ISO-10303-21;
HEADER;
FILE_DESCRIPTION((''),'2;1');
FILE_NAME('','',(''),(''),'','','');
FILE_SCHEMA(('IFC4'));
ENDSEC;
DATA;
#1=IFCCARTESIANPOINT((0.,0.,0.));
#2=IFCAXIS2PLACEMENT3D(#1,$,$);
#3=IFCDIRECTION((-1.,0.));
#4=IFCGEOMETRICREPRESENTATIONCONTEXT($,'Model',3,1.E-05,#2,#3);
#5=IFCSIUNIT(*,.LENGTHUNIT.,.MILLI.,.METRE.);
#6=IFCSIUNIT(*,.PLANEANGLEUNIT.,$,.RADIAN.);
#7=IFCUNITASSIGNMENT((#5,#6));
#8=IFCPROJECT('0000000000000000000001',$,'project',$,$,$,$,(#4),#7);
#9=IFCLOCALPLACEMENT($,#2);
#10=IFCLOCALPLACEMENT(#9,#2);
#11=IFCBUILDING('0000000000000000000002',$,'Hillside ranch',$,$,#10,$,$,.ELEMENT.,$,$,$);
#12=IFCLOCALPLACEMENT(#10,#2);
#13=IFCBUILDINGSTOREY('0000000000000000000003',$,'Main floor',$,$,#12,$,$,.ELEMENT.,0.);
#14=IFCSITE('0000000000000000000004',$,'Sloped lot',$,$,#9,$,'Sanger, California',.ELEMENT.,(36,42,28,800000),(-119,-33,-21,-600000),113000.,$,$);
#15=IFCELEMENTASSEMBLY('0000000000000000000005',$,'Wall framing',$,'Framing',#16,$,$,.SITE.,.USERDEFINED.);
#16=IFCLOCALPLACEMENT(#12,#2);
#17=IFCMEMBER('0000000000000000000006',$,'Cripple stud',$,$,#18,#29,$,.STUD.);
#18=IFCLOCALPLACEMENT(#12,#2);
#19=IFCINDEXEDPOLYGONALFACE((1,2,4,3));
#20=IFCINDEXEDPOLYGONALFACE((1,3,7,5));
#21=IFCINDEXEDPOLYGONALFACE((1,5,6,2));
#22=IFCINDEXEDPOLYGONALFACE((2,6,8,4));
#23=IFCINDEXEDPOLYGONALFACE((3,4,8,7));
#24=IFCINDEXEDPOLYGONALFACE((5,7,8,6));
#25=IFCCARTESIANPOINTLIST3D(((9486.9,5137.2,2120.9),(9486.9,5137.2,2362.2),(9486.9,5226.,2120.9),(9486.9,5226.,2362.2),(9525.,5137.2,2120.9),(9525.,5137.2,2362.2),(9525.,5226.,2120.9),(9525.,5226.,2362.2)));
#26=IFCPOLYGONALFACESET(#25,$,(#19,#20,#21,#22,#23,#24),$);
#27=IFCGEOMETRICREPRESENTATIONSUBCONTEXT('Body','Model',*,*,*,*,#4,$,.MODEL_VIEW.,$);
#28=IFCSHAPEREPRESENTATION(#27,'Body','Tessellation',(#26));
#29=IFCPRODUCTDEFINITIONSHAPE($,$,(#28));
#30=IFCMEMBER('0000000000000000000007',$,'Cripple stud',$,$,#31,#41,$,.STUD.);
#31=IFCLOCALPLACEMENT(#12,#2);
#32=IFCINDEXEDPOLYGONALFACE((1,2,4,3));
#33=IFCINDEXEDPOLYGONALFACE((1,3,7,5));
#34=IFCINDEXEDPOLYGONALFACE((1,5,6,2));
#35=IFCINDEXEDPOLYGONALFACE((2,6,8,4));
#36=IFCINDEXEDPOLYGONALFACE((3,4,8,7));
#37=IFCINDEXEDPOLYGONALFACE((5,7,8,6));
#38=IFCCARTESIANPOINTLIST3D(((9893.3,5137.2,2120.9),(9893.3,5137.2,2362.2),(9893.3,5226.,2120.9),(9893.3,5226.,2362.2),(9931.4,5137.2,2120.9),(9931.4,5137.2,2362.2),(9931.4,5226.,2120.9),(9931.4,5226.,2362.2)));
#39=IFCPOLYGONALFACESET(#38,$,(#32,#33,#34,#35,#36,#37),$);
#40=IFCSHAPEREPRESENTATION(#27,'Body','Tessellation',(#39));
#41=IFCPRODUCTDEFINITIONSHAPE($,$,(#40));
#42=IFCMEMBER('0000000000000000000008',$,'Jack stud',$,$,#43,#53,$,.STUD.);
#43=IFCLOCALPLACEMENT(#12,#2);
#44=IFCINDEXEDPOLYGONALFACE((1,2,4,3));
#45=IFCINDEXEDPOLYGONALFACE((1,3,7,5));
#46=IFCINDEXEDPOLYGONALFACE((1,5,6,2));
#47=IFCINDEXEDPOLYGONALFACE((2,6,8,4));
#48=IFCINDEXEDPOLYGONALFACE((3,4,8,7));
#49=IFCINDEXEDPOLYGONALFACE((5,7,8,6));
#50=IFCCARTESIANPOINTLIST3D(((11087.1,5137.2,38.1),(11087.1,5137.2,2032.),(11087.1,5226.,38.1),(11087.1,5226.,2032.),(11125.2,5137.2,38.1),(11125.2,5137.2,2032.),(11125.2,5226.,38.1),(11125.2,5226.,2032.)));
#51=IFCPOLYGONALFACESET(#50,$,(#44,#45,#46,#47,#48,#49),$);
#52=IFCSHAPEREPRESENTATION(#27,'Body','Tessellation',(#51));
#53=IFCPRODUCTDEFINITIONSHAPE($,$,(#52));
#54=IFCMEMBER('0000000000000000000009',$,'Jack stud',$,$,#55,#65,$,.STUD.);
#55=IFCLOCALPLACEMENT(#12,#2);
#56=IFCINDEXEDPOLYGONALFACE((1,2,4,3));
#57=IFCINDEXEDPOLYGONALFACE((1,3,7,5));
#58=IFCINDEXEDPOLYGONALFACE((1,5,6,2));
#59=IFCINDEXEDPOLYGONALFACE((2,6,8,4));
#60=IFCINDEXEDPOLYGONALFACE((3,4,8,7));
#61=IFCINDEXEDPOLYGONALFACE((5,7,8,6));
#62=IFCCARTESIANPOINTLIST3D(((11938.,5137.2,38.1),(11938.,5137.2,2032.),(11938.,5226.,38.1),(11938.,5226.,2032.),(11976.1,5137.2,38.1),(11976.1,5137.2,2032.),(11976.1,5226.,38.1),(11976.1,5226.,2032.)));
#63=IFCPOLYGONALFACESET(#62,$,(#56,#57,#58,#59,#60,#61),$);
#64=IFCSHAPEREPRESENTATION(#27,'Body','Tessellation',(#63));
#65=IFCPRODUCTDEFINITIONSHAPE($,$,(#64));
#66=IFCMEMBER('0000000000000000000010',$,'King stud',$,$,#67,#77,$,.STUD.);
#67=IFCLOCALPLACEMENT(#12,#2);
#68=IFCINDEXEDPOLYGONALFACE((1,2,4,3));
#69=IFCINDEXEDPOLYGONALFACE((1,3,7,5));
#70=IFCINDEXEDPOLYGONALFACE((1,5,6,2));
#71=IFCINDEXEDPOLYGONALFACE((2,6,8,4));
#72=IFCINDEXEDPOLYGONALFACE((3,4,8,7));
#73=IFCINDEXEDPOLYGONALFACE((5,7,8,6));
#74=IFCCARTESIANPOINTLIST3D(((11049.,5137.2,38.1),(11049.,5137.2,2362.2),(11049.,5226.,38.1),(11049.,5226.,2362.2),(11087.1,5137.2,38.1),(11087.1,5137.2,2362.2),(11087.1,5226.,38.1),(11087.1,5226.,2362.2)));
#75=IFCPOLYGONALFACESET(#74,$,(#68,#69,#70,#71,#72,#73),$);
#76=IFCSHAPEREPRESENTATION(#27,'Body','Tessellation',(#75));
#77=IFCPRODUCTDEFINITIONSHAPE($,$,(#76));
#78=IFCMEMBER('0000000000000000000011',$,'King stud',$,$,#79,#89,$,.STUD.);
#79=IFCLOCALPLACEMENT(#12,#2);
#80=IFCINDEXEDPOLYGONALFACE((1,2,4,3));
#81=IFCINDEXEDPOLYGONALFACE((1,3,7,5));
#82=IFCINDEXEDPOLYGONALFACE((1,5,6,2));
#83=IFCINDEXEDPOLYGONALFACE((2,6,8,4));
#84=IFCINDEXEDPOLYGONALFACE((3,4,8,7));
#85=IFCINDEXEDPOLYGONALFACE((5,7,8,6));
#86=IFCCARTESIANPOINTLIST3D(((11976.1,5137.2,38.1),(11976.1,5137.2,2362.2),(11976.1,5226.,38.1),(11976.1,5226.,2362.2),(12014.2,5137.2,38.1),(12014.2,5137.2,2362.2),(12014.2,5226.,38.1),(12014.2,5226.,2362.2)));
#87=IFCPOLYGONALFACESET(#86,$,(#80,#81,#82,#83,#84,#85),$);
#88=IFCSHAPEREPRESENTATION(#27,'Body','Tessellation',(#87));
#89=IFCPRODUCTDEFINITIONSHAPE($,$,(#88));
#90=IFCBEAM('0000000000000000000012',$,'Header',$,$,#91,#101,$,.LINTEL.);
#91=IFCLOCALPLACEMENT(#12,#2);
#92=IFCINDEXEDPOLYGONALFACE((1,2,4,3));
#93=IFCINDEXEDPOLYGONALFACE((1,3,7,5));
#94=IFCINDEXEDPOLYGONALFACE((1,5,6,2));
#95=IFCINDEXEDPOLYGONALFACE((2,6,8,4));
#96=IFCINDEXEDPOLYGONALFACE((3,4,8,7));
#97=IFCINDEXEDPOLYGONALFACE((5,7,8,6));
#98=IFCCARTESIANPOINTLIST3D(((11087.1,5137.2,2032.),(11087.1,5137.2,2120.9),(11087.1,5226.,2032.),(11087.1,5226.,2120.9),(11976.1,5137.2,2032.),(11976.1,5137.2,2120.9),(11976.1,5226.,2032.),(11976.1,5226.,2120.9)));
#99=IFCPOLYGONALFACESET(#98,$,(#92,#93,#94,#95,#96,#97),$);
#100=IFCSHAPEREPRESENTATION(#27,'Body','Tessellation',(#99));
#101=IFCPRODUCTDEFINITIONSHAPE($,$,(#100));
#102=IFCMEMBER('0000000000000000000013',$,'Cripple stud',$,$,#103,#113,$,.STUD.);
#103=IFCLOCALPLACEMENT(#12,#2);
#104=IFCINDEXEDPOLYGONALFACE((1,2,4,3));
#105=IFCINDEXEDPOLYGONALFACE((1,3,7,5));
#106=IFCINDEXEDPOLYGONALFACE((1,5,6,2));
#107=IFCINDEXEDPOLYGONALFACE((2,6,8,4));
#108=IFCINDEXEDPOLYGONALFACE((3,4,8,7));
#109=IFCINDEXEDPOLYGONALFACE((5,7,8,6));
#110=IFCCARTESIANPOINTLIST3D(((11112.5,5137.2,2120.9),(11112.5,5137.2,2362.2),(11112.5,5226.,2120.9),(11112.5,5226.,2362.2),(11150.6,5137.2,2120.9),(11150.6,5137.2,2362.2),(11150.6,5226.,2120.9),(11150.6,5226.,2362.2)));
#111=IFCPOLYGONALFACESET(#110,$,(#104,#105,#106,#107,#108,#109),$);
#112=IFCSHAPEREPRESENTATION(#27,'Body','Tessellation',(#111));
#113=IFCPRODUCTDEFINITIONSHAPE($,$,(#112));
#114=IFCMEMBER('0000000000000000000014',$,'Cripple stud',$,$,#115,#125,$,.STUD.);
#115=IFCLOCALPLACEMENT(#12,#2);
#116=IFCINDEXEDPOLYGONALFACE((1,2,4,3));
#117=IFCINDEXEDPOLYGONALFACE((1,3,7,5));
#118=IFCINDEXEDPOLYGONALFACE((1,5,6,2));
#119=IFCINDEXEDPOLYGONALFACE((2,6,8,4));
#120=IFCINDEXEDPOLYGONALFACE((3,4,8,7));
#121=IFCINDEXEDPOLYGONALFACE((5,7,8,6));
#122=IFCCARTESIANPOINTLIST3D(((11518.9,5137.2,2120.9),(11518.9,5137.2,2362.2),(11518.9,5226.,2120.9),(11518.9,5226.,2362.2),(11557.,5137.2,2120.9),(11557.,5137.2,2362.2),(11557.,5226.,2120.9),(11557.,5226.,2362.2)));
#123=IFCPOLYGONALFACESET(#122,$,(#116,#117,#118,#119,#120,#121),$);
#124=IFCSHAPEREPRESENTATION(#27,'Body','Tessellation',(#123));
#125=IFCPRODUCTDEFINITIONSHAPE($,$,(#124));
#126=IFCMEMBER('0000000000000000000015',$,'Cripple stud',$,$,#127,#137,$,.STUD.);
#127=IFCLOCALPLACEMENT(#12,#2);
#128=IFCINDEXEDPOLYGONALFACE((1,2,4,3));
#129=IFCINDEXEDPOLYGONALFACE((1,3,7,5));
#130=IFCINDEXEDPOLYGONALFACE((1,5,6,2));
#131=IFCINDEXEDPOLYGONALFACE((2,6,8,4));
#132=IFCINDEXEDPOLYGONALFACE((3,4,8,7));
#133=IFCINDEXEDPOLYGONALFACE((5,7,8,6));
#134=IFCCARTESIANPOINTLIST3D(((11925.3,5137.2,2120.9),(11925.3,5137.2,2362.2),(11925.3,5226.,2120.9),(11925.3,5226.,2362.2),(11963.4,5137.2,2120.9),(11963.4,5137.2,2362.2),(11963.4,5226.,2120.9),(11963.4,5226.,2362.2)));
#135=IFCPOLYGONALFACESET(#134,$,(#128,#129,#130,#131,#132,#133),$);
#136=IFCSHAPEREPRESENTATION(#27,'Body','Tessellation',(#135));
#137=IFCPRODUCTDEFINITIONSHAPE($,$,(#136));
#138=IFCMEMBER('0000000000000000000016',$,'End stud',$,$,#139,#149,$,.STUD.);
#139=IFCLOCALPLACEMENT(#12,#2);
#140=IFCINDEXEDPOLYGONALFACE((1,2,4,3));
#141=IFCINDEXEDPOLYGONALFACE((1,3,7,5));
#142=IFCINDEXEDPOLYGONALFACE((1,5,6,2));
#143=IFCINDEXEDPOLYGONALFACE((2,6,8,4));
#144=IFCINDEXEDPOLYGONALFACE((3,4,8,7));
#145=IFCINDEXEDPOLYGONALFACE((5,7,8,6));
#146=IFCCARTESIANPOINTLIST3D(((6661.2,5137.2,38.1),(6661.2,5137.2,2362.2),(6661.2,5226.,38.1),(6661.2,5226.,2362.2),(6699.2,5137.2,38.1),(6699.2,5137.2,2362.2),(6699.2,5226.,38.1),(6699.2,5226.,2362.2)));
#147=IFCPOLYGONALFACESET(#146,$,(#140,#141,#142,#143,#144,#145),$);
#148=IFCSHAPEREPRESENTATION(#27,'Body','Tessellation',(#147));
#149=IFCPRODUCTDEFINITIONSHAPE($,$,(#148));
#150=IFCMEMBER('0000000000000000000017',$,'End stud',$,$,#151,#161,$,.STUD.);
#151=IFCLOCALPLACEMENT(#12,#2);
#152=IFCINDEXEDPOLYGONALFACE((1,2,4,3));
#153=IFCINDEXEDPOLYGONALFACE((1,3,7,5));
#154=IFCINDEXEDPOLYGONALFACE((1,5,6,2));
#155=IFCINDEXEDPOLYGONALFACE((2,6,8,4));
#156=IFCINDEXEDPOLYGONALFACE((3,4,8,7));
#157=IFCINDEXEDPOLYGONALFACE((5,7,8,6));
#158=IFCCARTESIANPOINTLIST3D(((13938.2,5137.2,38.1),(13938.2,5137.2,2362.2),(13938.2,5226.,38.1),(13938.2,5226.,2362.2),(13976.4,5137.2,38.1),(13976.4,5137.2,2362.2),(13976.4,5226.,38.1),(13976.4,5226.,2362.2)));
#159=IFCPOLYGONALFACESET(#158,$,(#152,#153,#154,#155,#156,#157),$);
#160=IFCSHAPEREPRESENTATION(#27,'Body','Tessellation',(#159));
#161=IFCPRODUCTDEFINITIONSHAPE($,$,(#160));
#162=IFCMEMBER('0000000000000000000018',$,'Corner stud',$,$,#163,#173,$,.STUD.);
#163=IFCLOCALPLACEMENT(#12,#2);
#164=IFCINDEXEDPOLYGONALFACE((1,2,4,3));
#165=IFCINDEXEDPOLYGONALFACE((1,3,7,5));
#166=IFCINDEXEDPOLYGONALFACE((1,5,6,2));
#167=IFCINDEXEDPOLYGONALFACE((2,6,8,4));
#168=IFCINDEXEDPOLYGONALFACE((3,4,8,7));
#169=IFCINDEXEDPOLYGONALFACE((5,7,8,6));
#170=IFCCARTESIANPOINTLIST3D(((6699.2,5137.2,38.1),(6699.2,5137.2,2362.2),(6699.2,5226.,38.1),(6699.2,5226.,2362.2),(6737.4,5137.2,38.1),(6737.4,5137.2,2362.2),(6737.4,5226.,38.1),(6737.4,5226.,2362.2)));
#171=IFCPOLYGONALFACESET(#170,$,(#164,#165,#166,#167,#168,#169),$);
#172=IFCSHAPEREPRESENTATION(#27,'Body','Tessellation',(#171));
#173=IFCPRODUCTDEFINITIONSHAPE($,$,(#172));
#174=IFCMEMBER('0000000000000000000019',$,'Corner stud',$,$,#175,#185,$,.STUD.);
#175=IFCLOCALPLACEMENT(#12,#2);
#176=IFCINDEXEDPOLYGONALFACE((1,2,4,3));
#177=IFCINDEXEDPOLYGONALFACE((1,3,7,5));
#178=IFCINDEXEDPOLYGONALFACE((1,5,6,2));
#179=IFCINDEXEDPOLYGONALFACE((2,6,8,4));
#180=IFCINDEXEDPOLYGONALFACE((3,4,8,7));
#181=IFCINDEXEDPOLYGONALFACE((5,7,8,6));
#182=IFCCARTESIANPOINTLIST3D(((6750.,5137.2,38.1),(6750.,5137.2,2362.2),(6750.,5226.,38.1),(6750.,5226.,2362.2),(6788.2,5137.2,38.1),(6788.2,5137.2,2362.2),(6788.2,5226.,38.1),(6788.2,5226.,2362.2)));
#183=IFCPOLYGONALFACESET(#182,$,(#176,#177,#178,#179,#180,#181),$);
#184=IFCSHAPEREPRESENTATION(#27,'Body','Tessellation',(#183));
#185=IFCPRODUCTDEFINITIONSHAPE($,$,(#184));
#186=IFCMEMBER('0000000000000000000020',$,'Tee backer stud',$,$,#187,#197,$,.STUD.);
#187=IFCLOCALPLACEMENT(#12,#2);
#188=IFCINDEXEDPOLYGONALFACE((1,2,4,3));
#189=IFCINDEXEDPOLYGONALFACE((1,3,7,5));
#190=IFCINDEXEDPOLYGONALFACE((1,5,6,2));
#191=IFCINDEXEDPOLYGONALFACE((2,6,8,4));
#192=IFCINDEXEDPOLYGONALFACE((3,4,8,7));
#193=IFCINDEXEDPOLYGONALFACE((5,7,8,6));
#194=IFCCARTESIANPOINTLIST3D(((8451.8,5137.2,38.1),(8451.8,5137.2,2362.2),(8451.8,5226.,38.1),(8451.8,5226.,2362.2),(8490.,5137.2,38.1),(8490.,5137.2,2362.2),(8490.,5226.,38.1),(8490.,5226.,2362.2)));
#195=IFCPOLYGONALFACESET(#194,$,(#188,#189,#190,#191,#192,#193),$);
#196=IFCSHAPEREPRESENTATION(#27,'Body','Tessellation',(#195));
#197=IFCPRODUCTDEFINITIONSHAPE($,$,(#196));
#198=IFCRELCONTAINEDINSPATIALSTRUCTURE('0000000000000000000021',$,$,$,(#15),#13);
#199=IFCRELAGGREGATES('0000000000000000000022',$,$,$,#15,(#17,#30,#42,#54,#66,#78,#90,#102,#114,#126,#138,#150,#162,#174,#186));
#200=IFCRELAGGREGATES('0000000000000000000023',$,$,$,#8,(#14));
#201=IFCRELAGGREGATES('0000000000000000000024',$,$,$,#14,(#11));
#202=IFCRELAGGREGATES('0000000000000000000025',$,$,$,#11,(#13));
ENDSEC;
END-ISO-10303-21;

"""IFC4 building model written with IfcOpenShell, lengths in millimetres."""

from ifc_helpers import new_model, si_unit, direction, frame, origin, origin_with_axes, place, context, subcontext, project, spatial, polyline, outline, extrude, element, aggregate, save


model = new_model("IFC4")

# Units and contexts
model_context = context("Model", 3, precision=1e-05, world=origin(), true_north=direction((-1.0, 0.0)))
body_context = subcontext(model_context, "Body", "Model", "MODEL_VIEW")
ifc_project = project(units=[si_unit("LENGTHUNIT", "METRE", prefix="MILLI"), si_unit("PLANEANGLEUNIT", "RADIAN")], contexts=[model_context])

# Site, building, storey
site_placement = place(None, origin())
site = spatial("IfcSite", under=ifc_project, at=site_placement, Name="Sloped lot", LongName="Sanger, California", CompositionType="ELEMENT", RefLatitude=(36, 42, 28, 800000), RefLongitude=(-119, -33, -21, -600000), RefElevation=113000.0)
building_placement = place(site_placement, origin())
building = spatial("IfcBuilding", under=site, at=building_placement, Name="Hillside ranch", CompositionType="ELEMENT")
storey_placement = place(building_placement, origin())
storey = spatial("IfcBuildingStorey", under=building, at=storey_placement, Name="Main floor", CompositionType="ELEMENT", Elevation=0.0)

# Element assembly, members, beam
assembly_placement = place(storey_placement, origin_with_axes())
assembly = element("IfcElementAssembly", 1, at=assembly_placement, inside=storey, Name="Wall framing", ObjectType="Framing", AssemblyPlace="SITE", PredefinedType="USERDEFINED")
member_1_placement = place(storey_placement, origin_with_axes())
member_1 = element("IfcMember", 2, at=member_1_placement, Name="Cripple stud", PredefinedType="STUD", context=body_context, shape_type="SweptSolid", body=[
    extrude(outline(polyline([(0.0, 0.0), (38.1, 0.0), (38.1, 88.9), (0.0, 88.9), (0.0, 0.0)])), frame((9486.9, 5137.1, 2120.9), z_axis=(0.0, 0.0, 1.0), x_axis=(1.0, 0.0, 0.0)), (0.0, 0.0, 1.0), 241.3),
])
member_2_placement = place(storey_placement, origin_with_axes())
member_2 = element("IfcMember", 3, at=member_2_placement, Name="Cripple stud", PredefinedType="STUD", context=body_context, shape_type="SweptSolid", body=[
    extrude(outline(polyline([(0.0, 0.0), (38.1, 0.0), (38.1, 88.9), (0.0, 88.9), (0.0, 0.0)])), frame((9893.3, 5137.1, 2120.9), z_axis=(0.0, 0.0, 1.0), x_axis=(1.0, 0.0, 0.0)), (0.0, 0.0, 1.0), 241.3),
])
member_3_placement = place(storey_placement, origin_with_axes())
member_3 = element("IfcMember", 4, at=member_3_placement, Name="Jack stud", PredefinedType="STUD", context=body_context, shape_type="SweptSolid", body=[
    extrude(outline(polyline([(0.0, 0.0), (38.1, 0.0), (38.1, 88.9), (0.0, 88.9), (0.0, 0.0)])), frame((11087.1, 5137.1, 38.1), z_axis=(0.0, 0.0, 1.0), x_axis=(1.0, 0.0, 0.0)), (0.0, 0.0, 1.0), 1993.9),
])
member_4_placement = place(storey_placement, origin_with_axes())
member_4 = element("IfcMember", 5, at=member_4_placement, Name="Jack stud", PredefinedType="STUD", context=body_context, shape_type="SweptSolid", body=[
    extrude(outline(polyline([(0.0, 0.0), (38.1, 0.0), (38.1, 88.9), (0.0, 88.9), (0.0, 0.0)])), frame((11938.0, 5137.1, 38.1), z_axis=(0.0, 0.0, 1.0), x_axis=(1.0, 0.0, 0.0)), (0.0, 0.0, 1.0), 1993.9),
])
member_5_placement = place(storey_placement, origin_with_axes())
member_5 = element("IfcMember", 6, at=member_5_placement, Name="King stud", PredefinedType="STUD", context=body_context, shape_type="SweptSolid", body=[
    extrude(outline(polyline([(0.0, 0.0), (38.1, 0.0), (38.1, 88.9), (0.0, 88.9), (0.0, 0.0)])), frame((11049.0, 5137.1, 38.1), z_axis=(0.0, 0.0, 1.0), x_axis=(1.0, 0.0, 0.0)), (0.0, 0.0, 1.0), 2324.1),
])
member_6_placement = place(storey_placement, origin_with_axes())
member_6 = element("IfcMember", 7, at=member_6_placement, Name="King stud", PredefinedType="STUD", context=body_context, shape_type="SweptSolid", body=[
    extrude(outline(polyline([(0.0, 0.0), (38.1, 0.0), (38.1, 88.9), (0.0, 88.9), (0.0, 0.0)])), frame((11976.1, 5137.1, 38.1), z_axis=(0.0, 0.0, 1.0), x_axis=(1.0, 0.0, 0.0)), (0.0, 0.0, 1.0), 2324.1),
])
beam_placement = place(storey_placement, origin_with_axes())
beam = element("IfcBeam", 8, at=beam_placement, Name="Header", PredefinedType="LINTEL", context=body_context, shape_type="SweptSolid", body=[
    extrude(outline(polyline([(0.0, 0.0), (889.0, 0.0), (889.0, 88.9), (0.0, 88.9), (0.0, 0.0)])), frame((11087.1, 5137.1, 2032.0), z_axis=(0.0, 0.0, 1.0), x_axis=(1.0, 0.0, 0.0)), (0.0, 0.0, 1.0), 88.9),
])
member_7_placement = place(storey_placement, origin_with_axes())
member_7 = element("IfcMember", 9, at=member_7_placement, Name="Cripple stud", PredefinedType="STUD", context=body_context, shape_type="SweptSolid", body=[
    extrude(outline(polyline([(0.0, 0.0), (38.1, 0.0), (38.1, 88.9), (0.0, 88.9), (0.0, 0.0)])), frame((11112.5, 5137.1, 2120.9), z_axis=(0.0, 0.0, 1.0), x_axis=(1.0, 0.0, 0.0)), (0.0, 0.0, 1.0), 241.3),
])
member_8_placement = place(storey_placement, origin_with_axes())
member_8 = element("IfcMember", 10, at=member_8_placement, Name="Cripple stud", PredefinedType="STUD", context=body_context, shape_type="SweptSolid", body=[
    extrude(outline(polyline([(0.0, 0.0), (38.1, 0.0), (38.1, 88.9), (0.0, 88.9), (0.0, 0.0)])), frame((11518.9, 5137.1, 2120.9), z_axis=(0.0, 0.0, 1.0), x_axis=(1.0, 0.0, 0.0)), (0.0, 0.0, 1.0), 241.3),
])
member_9_placement = place(storey_placement, origin_with_axes())
member_9 = element("IfcMember", 11, at=member_9_placement, Name="Cripple stud", PredefinedType="STUD", context=body_context, shape_type="SweptSolid", body=[
    extrude(outline(polyline([(0.0, 0.0), (38.1, 0.0), (38.1, 88.9), (0.0, 88.9), (0.0, 0.0)])), frame((11925.3, 5137.1, 2120.9), z_axis=(0.0, 0.0, 1.0), x_axis=(1.0, 0.0, 0.0)), (0.0, 0.0, 1.0), 241.3),
])
member_10_placement = place(storey_placement, origin_with_axes())
member_10 = element("IfcMember", 12, at=member_10_placement, Name="End stud", PredefinedType="STUD", context=body_context, shape_type="SweptSolid", body=[
    extrude(outline(polyline([(0.0, 0.0), (38.1, 0.0), (38.1, 88.9), (0.0, 88.9), (0.0, 0.0)])), frame((6661.1, 5137.1, 38.1), z_axis=(0.0, 0.0, 1.0), x_axis=(1.0, 0.0, 0.0)), (0.0, 0.0, 1.0), 2324.1),
])
member_11_placement = place(storey_placement, origin_with_axes())
member_11 = element("IfcMember", 13, at=member_11_placement, Name="End stud", PredefinedType="STUD", context=body_context, shape_type="SweptSolid", body=[
    extrude(outline(polyline([(0.0, 0.0), (38.1, 0.0), (38.1, 88.9), (0.0, 88.9), (0.0, 0.0)])), frame((13938.2, 5137.1, 38.1), z_axis=(0.0, 0.0, 1.0), x_axis=(1.0, 0.0, 0.0)), (0.0, 0.0, 1.0), 2324.1),
])
member_12_placement = place(storey_placement, origin_with_axes())
member_12 = element("IfcMember", 14, at=member_12_placement, Name="Corner stud", PredefinedType="STUD", context=body_context, shape_type="SweptSolid", body=[
    extrude(outline(polyline([(0.0, 0.0), (38.1, 0.0), (38.1, 88.9), (0.0, 88.9), (0.0, 0.0)])), frame((6699.2, 5137.1, 38.1), z_axis=(0.0, 0.0, 1.0), x_axis=(1.0, 0.0, 0.0)), (0.0, 0.0, 1.0), 2324.1),
])
member_13_placement = place(storey_placement, origin_with_axes())
member_13 = element("IfcMember", 15, at=member_13_placement, Name="Corner stud", PredefinedType="STUD", context=body_context, shape_type="SweptSolid", body=[
    extrude(outline(polyline([(0.0, 0.0), (38.1, 0.0), (38.1, 88.9), (0.0, 88.9), (0.0, 0.0)])), frame((6750.1, 5137.1, 38.1), z_axis=(0.0, 0.0, 1.0), x_axis=(1.0, 0.0, 0.0)), (0.0, 0.0, 1.0), 2324.1),
])
member_14_placement = place(storey_placement, origin_with_axes())
member_14 = element("IfcMember", 16, at=member_14_placement, Name="Tee backer stud", PredefinedType="STUD", context=body_context, shape_type="SweptSolid", body=[
    extrude(outline(polyline([(0.0, 0.0), (38.1, 0.0), (38.1, 88.9), (0.0, 88.9), (0.0, 0.0)])), frame((8451.9, 5137.1, 38.1), z_axis=(0.0, 0.0, 1.0), x_axis=(1.0, 0.0, 0.0)), (0.0, 0.0, 1.0), 2324.1),
])
aggregate(assembly, [member_1, member_2, member_3, member_4, member_5, member_6, beam, member_7, member_8, member_9, member_10, member_11, member_12, member_13, member_14])

save(model, "model.ifc")
